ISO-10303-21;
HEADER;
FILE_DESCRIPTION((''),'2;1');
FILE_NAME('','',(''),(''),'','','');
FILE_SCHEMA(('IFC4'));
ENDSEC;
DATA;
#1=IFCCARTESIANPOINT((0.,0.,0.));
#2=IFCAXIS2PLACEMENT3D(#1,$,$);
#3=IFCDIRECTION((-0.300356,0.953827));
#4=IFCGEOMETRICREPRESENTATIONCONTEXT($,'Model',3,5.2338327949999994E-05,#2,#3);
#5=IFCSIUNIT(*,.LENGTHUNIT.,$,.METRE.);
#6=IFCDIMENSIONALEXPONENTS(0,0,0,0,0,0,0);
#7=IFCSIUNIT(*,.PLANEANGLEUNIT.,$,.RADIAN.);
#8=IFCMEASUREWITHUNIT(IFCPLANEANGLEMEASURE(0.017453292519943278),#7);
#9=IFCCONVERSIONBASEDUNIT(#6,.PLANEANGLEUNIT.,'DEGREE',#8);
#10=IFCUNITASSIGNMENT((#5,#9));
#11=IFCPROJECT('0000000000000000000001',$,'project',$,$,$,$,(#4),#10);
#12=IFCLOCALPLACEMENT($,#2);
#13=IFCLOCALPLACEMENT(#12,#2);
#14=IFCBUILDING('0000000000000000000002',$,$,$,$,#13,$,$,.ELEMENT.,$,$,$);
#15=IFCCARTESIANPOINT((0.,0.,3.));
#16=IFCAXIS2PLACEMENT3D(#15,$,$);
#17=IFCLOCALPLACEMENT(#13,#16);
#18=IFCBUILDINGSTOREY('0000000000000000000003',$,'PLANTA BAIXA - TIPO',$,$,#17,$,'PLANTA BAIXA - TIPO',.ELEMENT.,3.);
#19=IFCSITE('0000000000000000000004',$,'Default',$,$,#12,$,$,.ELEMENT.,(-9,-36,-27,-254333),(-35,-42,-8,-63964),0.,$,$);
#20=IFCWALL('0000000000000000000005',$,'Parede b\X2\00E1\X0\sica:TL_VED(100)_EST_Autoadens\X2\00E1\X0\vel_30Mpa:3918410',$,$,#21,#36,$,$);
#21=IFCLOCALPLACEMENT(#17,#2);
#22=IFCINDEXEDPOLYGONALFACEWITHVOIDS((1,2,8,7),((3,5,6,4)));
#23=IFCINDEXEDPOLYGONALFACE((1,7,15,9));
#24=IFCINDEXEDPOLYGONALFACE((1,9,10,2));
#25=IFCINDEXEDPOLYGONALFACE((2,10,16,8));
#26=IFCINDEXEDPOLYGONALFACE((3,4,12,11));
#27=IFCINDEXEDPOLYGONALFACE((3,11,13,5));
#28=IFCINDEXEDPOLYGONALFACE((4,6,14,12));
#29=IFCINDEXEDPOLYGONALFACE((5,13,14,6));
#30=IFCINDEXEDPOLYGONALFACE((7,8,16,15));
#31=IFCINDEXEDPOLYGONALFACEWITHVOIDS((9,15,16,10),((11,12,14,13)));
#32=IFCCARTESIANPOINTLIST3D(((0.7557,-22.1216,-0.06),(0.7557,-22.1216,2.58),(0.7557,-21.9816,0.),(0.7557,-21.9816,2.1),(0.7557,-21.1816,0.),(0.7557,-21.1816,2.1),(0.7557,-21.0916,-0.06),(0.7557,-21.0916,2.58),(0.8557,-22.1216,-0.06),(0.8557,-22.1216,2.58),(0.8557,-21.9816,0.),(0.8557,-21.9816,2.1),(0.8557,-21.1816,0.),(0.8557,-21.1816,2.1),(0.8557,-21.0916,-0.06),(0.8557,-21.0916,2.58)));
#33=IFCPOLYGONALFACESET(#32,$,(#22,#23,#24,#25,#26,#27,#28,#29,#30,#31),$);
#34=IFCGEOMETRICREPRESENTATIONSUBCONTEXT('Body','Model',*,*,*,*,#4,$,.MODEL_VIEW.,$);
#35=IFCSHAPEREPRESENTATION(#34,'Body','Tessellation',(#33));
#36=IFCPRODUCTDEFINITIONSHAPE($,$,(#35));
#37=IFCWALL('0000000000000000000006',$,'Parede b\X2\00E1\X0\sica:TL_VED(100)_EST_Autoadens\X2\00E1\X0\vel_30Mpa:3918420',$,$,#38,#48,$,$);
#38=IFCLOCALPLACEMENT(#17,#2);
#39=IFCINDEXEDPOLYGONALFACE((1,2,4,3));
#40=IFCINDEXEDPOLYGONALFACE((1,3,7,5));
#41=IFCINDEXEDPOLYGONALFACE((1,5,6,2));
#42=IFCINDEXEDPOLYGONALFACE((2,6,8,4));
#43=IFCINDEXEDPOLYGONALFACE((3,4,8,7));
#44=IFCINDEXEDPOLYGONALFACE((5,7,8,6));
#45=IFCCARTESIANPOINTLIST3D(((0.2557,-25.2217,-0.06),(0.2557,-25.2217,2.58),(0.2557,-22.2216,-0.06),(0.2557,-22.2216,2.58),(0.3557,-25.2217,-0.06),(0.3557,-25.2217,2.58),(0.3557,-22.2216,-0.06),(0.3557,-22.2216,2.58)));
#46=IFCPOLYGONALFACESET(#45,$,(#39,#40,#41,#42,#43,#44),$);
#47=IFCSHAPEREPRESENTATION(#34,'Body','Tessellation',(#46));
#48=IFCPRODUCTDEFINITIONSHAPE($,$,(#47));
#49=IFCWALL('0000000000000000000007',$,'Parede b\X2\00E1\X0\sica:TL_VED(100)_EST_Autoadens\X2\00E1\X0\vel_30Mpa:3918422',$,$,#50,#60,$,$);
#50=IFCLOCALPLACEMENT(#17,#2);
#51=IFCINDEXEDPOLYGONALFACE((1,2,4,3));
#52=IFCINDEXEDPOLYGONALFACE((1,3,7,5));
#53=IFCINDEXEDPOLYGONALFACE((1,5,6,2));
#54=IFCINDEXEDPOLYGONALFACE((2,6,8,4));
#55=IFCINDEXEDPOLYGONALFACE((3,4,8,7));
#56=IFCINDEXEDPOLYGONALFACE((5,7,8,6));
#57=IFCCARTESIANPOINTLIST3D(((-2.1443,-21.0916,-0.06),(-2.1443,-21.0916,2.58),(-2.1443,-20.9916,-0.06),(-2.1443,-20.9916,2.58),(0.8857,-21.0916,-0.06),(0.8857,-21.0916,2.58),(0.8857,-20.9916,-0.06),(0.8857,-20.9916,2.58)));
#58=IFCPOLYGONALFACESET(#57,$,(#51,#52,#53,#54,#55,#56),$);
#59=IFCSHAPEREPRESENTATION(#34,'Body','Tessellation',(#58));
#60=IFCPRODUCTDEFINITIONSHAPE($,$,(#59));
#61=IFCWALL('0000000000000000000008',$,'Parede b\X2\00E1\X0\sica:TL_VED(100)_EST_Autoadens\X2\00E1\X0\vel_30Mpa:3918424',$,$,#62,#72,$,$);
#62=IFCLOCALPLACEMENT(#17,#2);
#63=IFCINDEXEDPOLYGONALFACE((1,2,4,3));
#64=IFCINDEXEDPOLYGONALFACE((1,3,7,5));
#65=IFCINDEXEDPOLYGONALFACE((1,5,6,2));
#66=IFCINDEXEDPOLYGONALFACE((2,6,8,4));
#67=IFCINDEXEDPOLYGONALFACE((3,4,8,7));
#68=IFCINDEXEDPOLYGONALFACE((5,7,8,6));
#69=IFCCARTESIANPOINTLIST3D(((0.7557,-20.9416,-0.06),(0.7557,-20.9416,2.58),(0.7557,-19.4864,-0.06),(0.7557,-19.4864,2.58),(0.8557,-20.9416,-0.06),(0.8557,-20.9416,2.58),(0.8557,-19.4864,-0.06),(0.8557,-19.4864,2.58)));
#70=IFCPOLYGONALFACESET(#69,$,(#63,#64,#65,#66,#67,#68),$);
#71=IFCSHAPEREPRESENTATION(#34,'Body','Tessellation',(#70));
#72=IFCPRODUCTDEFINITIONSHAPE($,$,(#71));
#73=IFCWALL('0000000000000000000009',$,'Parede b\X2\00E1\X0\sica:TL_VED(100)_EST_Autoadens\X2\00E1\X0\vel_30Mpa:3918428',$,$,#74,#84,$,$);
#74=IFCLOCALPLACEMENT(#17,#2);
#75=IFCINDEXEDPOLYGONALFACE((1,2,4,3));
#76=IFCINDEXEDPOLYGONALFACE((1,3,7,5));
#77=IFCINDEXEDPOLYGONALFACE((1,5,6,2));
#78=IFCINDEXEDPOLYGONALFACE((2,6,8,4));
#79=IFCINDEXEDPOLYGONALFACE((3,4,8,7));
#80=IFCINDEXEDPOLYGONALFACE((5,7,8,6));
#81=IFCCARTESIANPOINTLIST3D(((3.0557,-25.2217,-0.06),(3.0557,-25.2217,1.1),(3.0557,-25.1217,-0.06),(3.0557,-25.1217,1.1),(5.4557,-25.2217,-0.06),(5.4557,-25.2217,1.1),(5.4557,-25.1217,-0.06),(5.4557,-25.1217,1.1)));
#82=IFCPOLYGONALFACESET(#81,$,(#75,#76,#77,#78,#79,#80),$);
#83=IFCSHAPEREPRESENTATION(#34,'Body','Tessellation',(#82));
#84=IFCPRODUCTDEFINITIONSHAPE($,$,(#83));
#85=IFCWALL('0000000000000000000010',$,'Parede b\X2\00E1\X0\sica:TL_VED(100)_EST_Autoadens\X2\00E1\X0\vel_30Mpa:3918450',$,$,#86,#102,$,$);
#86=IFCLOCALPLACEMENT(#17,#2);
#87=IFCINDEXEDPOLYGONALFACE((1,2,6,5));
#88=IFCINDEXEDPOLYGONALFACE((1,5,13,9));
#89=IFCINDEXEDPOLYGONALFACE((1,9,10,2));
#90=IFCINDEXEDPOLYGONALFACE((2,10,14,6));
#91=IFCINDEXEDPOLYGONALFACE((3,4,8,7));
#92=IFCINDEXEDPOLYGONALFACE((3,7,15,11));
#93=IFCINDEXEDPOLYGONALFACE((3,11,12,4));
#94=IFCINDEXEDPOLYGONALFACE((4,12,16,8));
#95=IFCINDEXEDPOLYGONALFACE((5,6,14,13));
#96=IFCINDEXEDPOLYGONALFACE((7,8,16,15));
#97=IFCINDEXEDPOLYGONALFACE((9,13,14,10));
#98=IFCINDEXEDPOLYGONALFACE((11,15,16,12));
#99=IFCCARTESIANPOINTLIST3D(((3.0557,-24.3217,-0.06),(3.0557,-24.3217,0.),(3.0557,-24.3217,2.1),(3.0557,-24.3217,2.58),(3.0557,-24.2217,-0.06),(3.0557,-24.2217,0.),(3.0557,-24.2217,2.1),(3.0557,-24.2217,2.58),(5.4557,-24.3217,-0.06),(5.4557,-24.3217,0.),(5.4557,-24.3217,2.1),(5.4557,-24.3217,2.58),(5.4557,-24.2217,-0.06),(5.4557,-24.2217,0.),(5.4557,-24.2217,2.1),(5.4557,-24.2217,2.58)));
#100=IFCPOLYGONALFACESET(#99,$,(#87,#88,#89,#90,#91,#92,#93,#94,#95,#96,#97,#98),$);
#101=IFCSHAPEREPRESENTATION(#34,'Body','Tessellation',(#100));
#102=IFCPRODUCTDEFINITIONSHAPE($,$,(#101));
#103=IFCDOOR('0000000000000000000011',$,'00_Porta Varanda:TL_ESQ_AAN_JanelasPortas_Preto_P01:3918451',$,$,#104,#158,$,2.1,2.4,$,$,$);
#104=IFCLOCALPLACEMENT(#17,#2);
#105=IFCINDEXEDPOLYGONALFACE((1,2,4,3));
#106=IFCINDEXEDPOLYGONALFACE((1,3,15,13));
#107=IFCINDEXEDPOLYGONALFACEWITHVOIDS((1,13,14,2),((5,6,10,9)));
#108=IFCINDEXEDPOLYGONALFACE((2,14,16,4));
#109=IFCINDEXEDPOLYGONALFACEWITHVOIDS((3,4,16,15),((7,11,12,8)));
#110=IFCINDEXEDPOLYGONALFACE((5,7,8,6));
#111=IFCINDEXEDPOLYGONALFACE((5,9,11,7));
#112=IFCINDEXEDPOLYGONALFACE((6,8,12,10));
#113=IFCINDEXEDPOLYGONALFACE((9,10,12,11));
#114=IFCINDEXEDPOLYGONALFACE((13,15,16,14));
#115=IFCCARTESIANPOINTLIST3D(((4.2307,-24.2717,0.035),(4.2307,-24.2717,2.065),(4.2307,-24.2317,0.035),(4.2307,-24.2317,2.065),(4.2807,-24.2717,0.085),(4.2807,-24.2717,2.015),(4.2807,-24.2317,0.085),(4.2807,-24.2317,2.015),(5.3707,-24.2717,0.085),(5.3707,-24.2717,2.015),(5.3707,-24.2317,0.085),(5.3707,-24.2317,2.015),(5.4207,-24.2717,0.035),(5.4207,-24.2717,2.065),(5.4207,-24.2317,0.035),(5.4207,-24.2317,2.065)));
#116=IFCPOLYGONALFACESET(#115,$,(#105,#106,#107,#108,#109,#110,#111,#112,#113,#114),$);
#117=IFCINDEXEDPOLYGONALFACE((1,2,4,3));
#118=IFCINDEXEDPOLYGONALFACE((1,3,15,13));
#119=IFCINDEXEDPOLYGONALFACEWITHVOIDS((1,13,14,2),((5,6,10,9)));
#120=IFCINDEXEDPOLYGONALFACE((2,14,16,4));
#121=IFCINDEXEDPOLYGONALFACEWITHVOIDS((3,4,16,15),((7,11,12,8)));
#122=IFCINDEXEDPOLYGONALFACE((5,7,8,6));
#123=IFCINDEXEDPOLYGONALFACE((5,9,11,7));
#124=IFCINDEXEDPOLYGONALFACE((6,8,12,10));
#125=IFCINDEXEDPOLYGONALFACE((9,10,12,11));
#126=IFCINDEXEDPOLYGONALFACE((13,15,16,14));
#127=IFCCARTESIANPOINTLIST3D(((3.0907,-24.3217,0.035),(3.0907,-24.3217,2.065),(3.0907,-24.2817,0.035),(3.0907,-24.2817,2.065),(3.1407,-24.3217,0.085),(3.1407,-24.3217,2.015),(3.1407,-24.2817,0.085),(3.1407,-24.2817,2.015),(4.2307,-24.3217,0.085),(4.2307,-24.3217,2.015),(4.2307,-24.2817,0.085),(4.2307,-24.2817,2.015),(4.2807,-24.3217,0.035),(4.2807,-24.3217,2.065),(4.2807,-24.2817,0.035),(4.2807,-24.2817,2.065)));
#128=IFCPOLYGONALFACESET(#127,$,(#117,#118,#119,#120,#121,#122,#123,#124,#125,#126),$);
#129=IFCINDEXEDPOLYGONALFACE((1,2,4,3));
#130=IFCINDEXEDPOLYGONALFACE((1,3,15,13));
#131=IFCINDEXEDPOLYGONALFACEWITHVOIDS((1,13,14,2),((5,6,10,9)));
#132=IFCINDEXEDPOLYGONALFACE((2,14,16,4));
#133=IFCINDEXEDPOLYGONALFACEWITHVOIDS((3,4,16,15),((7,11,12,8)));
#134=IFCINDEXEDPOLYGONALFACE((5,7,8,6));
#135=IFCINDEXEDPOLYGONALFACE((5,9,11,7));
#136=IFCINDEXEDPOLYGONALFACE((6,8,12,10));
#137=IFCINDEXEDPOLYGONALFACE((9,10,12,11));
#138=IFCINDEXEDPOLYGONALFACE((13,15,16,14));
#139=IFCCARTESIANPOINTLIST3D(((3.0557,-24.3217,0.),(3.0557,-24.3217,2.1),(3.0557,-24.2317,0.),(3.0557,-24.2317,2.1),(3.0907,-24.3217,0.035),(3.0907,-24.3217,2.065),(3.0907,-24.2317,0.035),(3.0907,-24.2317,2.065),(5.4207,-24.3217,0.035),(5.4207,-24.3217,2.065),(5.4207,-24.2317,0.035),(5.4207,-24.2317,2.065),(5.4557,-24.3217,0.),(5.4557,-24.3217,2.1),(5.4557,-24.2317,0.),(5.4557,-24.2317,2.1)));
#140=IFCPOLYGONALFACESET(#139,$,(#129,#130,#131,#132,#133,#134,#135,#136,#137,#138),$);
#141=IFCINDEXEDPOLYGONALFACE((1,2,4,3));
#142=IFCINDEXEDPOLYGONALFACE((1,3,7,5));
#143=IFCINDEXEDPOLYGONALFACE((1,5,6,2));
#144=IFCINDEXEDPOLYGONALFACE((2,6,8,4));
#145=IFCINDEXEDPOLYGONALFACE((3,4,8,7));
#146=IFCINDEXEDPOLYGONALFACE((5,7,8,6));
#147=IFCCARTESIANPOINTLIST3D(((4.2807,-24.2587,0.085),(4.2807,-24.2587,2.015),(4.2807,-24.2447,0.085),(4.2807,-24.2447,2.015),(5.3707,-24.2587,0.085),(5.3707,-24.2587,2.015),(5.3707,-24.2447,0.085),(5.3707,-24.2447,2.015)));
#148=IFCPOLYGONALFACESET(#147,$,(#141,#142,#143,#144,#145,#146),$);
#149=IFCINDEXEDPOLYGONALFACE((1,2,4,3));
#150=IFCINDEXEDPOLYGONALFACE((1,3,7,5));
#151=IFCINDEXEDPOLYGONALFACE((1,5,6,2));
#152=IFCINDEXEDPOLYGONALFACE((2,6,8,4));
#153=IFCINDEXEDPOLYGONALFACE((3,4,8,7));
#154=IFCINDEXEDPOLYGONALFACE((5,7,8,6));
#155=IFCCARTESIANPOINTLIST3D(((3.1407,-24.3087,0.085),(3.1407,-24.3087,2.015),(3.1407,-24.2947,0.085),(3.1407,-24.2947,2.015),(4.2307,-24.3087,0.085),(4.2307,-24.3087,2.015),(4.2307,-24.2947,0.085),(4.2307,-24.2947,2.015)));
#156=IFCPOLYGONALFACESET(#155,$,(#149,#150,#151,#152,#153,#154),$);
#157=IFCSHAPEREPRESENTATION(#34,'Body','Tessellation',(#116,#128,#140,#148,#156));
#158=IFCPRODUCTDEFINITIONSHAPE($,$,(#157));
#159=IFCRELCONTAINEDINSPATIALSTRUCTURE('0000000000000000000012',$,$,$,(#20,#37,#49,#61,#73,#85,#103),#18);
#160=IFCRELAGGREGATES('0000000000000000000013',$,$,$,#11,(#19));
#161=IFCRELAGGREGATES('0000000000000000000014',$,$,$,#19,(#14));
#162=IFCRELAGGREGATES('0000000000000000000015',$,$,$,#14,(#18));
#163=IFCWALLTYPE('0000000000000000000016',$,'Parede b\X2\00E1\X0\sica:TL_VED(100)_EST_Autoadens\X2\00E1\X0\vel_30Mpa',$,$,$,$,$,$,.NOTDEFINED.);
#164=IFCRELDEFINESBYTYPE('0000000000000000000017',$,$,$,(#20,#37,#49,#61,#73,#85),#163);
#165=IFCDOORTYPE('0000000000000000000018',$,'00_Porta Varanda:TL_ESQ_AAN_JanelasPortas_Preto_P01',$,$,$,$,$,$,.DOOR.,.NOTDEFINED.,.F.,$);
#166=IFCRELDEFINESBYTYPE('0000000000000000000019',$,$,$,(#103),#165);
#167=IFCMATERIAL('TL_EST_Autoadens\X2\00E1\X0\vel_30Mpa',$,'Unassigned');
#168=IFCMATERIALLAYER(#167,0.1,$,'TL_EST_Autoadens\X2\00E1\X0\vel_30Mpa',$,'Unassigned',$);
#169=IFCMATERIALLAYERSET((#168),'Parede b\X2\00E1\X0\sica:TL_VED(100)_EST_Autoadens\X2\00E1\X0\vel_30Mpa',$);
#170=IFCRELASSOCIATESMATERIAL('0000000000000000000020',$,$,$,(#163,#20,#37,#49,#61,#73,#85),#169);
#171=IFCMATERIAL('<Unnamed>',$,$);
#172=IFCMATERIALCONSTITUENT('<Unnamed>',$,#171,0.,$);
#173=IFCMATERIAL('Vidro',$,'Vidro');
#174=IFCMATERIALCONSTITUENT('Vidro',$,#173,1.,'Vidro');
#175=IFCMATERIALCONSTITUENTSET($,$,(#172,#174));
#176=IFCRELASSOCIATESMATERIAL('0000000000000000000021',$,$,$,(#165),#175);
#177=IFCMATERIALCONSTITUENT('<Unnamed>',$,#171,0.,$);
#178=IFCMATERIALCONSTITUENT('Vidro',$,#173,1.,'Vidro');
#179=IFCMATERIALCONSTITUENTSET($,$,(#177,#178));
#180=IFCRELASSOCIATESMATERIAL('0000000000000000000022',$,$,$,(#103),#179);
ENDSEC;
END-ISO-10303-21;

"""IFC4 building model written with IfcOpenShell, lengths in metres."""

from ifc_helpers import new_model, entity, si_unit, converted_unit, direction, frame, frame_2d, origin, place, context, subcontext, project, spatial, polyline, rectangle, outline, extrude, source, transform, mapped, material, layer, layer_set, layer_usage, constituent, constituent_set, type_object, type_shapes, element, fill, save


model = new_model("IFC4")

# Units and contexts
model_context = context("Model", 3, precision=5.2338327949999994e-05, world=origin(), true_north=direction((-0.300356, 0.953827)))
body_context = subcontext(model_context, "Body", "Model", "MODEL_VIEW")
ifc_project = project(units=[si_unit("LENGTHUNIT", "METRE"), converted_unit("PLANEANGLEUNIT", "DEGREE", entity("IfcPlaneAngleMeasure", 0.017453292519943278), si_unit("PLANEANGLEUNIT", "RADIAN"), dimensions=[0, 0, 0, 0, 0, 0, 0])], contexts=[model_context])

# Site, building, storey
site_placement = place(None, origin())
site = spatial("IfcSite", under=ifc_project, at=site_placement, Name="Default", CompositionType="ELEMENT", RefLatitude=(-9, -36, -27, -254333), RefLongitude=(-35, -42, -8, -63964), RefElevation=0.0)
building_placement = place(site_placement, origin())
building = spatial("IfcBuilding", under=site, at=building_placement, CompositionType="ELEMENT")
storey_placement = place(building_placement, frame((0.0, 0.0, 3.0)))
storey = spatial("IfcBuildingStorey", under=building, at=storey_placement, Name="PLANTA BAIXA - TIPO", LongName="PLANTA BAIXA - TIPO", CompositionType="ELEMENT", Elevation=3.0)

# Wall, opening
ifc_material_1 = material(Name="TL_EST_Autoadensável_30Mpa", Category="Unassigned")
ifc_layer_1 = layer(ifc_material_1, 0.1, Name="TL_EST_Autoadensável_30Mpa", Category="Unassigned")
ifc_layer_set_1 = layer_set([ifc_layer_1], Name="Parede básica:TL_VED(100)_EST_Autoadensável_30Mpa")
ifc_layer_usage_1 = layer_usage(ifc_layer_set_1, "AXIS2", "NEGATIVE", 0.05)
wall_type_1 = type_object("IfcWallType", Name="Parede básica:TL_VED(100)_EST_Autoadensável_30Mpa", PredefinedType="NOTDEFINED", material=ifc_layer_set_1)
wall_1_placement = place(storey_placement, frame((0.8057, -22.1216, -0.06), z_axis=(0.0, 0.0, 1.0), x_axis=(0.0, 1.0, 0.0)))
wall_1 = element("IfcWall", 1, at=wall_1_placement, inside=storey, type_object=wall_type_1, material=ifc_layer_usage_1, Name="Parede básica:TL_VED(100)_EST_Autoadensável_30Mpa:3918410", context=body_context, shape_type="SweptSolid", body=[
    extrude(rectangle(XDim=1.03, YDim=0.1, at=frame_2d((0.515, 0.0), x_axis=(-1.0, 0.0))), origin(), (0.0, 0.0, 1.0), 2.64),
])
opening_1_placement = place(wall_1_placement, frame((0.14, -0.05, 0.06)))
element("IfcOpeningElement", 2, at=opening_1_placement, cuts=wall_1, PredefinedType="OPENING", context=body_context, shape_type="SweptSolid", body=[
    extrude(rectangle(XDim=2.1, YDim=0.8, at=frame_2d((1.05, 0.4), x_axis=(1.0, 0.0))), frame((0.0, 0.0, 0.0), z_axis=(0.0, 1.0, 0.0), x_axis=(0.0, 0.0, 1.0)), (0.0, 0.0, 1.0), 0.1),
])

# Walls
ifc_layer_usage_2 = layer_usage(ifc_layer_set_1, "AXIS2", "POSITIVE", -0.05)
wall_2_placement = place(storey_placement, frame((0.3057, -25.2217, -0.06), z_axis=(0.0, 0.0, 1.0), x_axis=(0.0, 1.0, 0.0)))
element("IfcWall", 3, at=wall_2_placement, inside=storey, type_object=wall_type_1, material=ifc_layer_usage_2, Name="Parede básica:TL_VED(100)_EST_Autoadensável_30Mpa:3918420", context=body_context, shape_type="SweptSolid", body=[
    extrude(rectangle(XDim=3.0001, YDim=0.1, at=frame_2d((1.5001, 0.0), x_axis=(-1.0, 0.0))), origin(), (0.0, 0.0, 1.0), 2.64),
])
ifc_layer_usage_3 = layer_usage(ifc_layer_set_1, "AXIS2", "POSITIVE", -0.05)
wall_3_placement = place(storey_placement, frame((0.8857, -21.0416, -0.06), z_axis=(0.0, 0.0, 1.0), x_axis=(-1.0, 0.0, 0.0)))
element("IfcWall", 4, at=wall_3_placement, inside=storey, type_object=wall_type_1, material=ifc_layer_usage_3, Name="Parede básica:TL_VED(100)_EST_Autoadensável_30Mpa:3918422", context=body_context, shape_type="SweptSolid", body=[
    extrude(rectangle(XDim=3.03, YDim=0.1, at=frame_2d((1.515, 0.0), x_axis=(-1.0, 0.0))), origin(), (0.0, 0.0, 1.0), 2.64),
])
ifc_layer_usage_4 = layer_usage(ifc_layer_set_1, "AXIS2", "NEGATIVE", 0.05)
wall_4_placement = place(storey_placement, frame((0.8057, -19.4864, -0.06), z_axis=(0.0, 0.0, 1.0), x_axis=(0.0, -1.0, 0.0)))
element("IfcWall", 5, at=wall_4_placement, inside=storey, type_object=wall_type_1, material=ifc_layer_usage_4, Name="Parede básica:TL_VED(100)_EST_Autoadensável_30Mpa:3918424", context=body_context, shape_type="SweptSolid", body=[
    extrude(rectangle(XDim=1.4552, YDim=0.1, at=frame_2d((0.7276, 0.0), x_axis=(-1.0, 0.0))), origin(), (0.0, 0.0, 1.0), 2.64),
])

# Wall
ifc_layer_usage_5 = layer_usage(ifc_layer_set_1, "AXIS2", "POSITIVE", -0.05)
wall_5_placement = place(storey_placement, frame((3.0557, -25.1717, -0.06)))
element("IfcWall", 6, at=wall_5_placement, inside=storey, type_object=wall_type_1, material=ifc_layer_usage_5, Name="Parede básica:TL_VED(100)_EST_Autoadensável_30Mpa:3918428", context=body_context, shape_type="SweptSolid", body=[
    extrude(rectangle(XDim=2.4, YDim=0.1, at=frame_2d((1.2, 0.0), x_axis=(-1.0, 0.0))), origin(), (0.0, 0.0, 1.0), 1.16),
])

# Wall, opening, door
ifc_layer_usage_6 = layer_usage(ifc_layer_set_1, "AXIS2", "POSITIVE", -0.05)
wall_6_placement = place(storey_placement, frame((3.0557, -24.2717, -0.06)))
wall_6 = element("IfcWall", 7, at=wall_6_placement, inside=storey, type_object=wall_type_1, material=ifc_layer_usage_6, Name="Parede básica:TL_VED(100)_EST_Autoadensável_30Mpa:3918450", context=body_context, shape_type="SweptSolid", body=[
    extrude(rectangle(XDim=2.4, YDim=0.1, at=frame_2d((1.2, 0.0), x_axis=(-1.0, 0.0))), origin(), (0.0, 0.0, 1.0), 2.64),
])
opening_2_placement = place(wall_6_placement, frame((0.0, -0.05, 0.06)))
opening_2 = element("IfcOpeningElement", 8, at=opening_2_placement, cuts=wall_6, PredefinedType="OPENING", context=body_context, shape_type="SweptSolid", body=[
    extrude(rectangle(XDim=2.1, YDim=2.4, at=frame_2d((1.05, 1.2), x_axis=(1.0, 0.0))), frame((0.0, 0.0, 0.0), z_axis=(0.0, 1.0, 0.0), x_axis=(0.0, 0.0, 1.0)), (0.0, 0.0, 1.0), 0.1),
])
ifc_material_2 = material(Name="<Unnamed>")
ifc_constituent_1 = constituent(ifc_material_2, Name="<Unnamed>", fraction=0.0)
ifc_material_3 = material(Name="Vidro", Category="Vidro")
ifc_constituent_2 = constituent(ifc_material_3, Name="Vidro", Category="Vidro", fraction=1.0)
ifc_constituent_set_1 = constituent_set(constituents=[ifc_constituent_1, ifc_constituent_2])
ifc_constituent_3 = constituent(ifc_material_2, Name="<Unnamed>", fraction=0.0)
ifc_constituent_4 = constituent(ifc_material_3, Name="Vidro", Category="Vidro", fraction=1.0)
ifc_constituent_set_2 = constituent_set(constituents=[ifc_constituent_3, ifc_constituent_4])
door_type = type_object("IfcDoorType", Name="00_Porta Varanda:TL_ESQ_AAN_JanelasPortas_Preto_P01", OperationType="NOTDEFINED", ParameterTakesPrecedence=False, PredefinedType="DOOR", material=ifc_constituent_set_2)
shared_shape_1 = source(origin(), body_context, "Body", "SweptSolid", [
    extrude(outline(polyline([(-1.015, -0.595), (1.015, -0.595), (1.015, 0.595), (-1.015, 0.595), (-1.015, -0.595)]), holes=[polyline([(0.965, -0.545), (-0.965, -0.545), (-0.965, 0.545), (0.965, 0.545), (0.965, -0.545)])]), frame((1.77, 0.05, 1.05), z_axis=(0.0, 1.0, 0.0), x_axis=(0.0, 0.0, 1.0)), (0.0, 0.0, 1.0), 0.04),
    extrude(outline(polyline([(-1.015, -0.595), (1.015, -0.595), (1.015, 0.595), (-1.015, 0.595), (-1.015, -0.595)]), holes=[polyline([(0.965, -0.545), (-0.965, -0.545), (-0.965, 0.545), (0.965, 0.545), (0.965, -0.545)])]), frame((0.63, 0.0, 1.05), z_axis=(0.0, 1.0, 0.0), x_axis=(0.0, 0.0, -1.0)), (0.0, 0.0, 1.0), 0.04),
    extrude(outline(polyline([(-1.05, -1.2), (1.05, -1.2), (1.05, 1.2), (-1.05, 1.2), (-1.05, -1.2)]), holes=[polyline([(1.015, -1.165), (-1.015, -1.165), (-1.015, 1.165), (1.015, 1.165), (1.015, -1.165)])]), frame((1.2, 0.0, 1.05), z_axis=(0.0, 1.0, 0.0), x_axis=(0.0, 0.0, -1.0)), (0.0, 0.0, 1.0), 0.09),
    extrude(rectangle(XDim=0.014, YDim=1.09, at=frame_2d((0.0, 0.0), x_axis=(1.0, 0.0))), frame((1.77, 0.07, 0.085), z_axis=(0.0, 0.0, 1.0), x_axis=(0.0, -1.0, 0.0)), (0.0, 0.0, 1.0), 1.93),
    extrude(rectangle(XDim=0.014, YDim=1.09, at=frame_2d((0.0, 0.0), x_axis=(1.0, 0.0))), frame((0.63, 0.02, 0.085), z_axis=(0.0, 0.0, 1.0), x_axis=(0.0, -1.0, 0.0)), (0.0, 0.0, 1.0), 1.93),
])
type_shapes(door_type, [shared_shape_1])
door_placement = place(opening_2_placement, origin())
door = element("IfcDoor", 9, at=door_placement, inside=storey, type_object=door_type, material=ifc_constituent_set_1, Name="00_Porta Varanda:TL_ESQ_AAN_JanelasPortas_Preto_P01:3918451", OverallHeight=2.1, OverallWidth=2.4, context=body_context, shape_type="MappedRepresentation", body=[
    mapped(shared_shape_1, transform((0.0, 0.0, 0.0), scale=1.0)),
])
fill(opening_2, door)

save(model, "model.ifc")
